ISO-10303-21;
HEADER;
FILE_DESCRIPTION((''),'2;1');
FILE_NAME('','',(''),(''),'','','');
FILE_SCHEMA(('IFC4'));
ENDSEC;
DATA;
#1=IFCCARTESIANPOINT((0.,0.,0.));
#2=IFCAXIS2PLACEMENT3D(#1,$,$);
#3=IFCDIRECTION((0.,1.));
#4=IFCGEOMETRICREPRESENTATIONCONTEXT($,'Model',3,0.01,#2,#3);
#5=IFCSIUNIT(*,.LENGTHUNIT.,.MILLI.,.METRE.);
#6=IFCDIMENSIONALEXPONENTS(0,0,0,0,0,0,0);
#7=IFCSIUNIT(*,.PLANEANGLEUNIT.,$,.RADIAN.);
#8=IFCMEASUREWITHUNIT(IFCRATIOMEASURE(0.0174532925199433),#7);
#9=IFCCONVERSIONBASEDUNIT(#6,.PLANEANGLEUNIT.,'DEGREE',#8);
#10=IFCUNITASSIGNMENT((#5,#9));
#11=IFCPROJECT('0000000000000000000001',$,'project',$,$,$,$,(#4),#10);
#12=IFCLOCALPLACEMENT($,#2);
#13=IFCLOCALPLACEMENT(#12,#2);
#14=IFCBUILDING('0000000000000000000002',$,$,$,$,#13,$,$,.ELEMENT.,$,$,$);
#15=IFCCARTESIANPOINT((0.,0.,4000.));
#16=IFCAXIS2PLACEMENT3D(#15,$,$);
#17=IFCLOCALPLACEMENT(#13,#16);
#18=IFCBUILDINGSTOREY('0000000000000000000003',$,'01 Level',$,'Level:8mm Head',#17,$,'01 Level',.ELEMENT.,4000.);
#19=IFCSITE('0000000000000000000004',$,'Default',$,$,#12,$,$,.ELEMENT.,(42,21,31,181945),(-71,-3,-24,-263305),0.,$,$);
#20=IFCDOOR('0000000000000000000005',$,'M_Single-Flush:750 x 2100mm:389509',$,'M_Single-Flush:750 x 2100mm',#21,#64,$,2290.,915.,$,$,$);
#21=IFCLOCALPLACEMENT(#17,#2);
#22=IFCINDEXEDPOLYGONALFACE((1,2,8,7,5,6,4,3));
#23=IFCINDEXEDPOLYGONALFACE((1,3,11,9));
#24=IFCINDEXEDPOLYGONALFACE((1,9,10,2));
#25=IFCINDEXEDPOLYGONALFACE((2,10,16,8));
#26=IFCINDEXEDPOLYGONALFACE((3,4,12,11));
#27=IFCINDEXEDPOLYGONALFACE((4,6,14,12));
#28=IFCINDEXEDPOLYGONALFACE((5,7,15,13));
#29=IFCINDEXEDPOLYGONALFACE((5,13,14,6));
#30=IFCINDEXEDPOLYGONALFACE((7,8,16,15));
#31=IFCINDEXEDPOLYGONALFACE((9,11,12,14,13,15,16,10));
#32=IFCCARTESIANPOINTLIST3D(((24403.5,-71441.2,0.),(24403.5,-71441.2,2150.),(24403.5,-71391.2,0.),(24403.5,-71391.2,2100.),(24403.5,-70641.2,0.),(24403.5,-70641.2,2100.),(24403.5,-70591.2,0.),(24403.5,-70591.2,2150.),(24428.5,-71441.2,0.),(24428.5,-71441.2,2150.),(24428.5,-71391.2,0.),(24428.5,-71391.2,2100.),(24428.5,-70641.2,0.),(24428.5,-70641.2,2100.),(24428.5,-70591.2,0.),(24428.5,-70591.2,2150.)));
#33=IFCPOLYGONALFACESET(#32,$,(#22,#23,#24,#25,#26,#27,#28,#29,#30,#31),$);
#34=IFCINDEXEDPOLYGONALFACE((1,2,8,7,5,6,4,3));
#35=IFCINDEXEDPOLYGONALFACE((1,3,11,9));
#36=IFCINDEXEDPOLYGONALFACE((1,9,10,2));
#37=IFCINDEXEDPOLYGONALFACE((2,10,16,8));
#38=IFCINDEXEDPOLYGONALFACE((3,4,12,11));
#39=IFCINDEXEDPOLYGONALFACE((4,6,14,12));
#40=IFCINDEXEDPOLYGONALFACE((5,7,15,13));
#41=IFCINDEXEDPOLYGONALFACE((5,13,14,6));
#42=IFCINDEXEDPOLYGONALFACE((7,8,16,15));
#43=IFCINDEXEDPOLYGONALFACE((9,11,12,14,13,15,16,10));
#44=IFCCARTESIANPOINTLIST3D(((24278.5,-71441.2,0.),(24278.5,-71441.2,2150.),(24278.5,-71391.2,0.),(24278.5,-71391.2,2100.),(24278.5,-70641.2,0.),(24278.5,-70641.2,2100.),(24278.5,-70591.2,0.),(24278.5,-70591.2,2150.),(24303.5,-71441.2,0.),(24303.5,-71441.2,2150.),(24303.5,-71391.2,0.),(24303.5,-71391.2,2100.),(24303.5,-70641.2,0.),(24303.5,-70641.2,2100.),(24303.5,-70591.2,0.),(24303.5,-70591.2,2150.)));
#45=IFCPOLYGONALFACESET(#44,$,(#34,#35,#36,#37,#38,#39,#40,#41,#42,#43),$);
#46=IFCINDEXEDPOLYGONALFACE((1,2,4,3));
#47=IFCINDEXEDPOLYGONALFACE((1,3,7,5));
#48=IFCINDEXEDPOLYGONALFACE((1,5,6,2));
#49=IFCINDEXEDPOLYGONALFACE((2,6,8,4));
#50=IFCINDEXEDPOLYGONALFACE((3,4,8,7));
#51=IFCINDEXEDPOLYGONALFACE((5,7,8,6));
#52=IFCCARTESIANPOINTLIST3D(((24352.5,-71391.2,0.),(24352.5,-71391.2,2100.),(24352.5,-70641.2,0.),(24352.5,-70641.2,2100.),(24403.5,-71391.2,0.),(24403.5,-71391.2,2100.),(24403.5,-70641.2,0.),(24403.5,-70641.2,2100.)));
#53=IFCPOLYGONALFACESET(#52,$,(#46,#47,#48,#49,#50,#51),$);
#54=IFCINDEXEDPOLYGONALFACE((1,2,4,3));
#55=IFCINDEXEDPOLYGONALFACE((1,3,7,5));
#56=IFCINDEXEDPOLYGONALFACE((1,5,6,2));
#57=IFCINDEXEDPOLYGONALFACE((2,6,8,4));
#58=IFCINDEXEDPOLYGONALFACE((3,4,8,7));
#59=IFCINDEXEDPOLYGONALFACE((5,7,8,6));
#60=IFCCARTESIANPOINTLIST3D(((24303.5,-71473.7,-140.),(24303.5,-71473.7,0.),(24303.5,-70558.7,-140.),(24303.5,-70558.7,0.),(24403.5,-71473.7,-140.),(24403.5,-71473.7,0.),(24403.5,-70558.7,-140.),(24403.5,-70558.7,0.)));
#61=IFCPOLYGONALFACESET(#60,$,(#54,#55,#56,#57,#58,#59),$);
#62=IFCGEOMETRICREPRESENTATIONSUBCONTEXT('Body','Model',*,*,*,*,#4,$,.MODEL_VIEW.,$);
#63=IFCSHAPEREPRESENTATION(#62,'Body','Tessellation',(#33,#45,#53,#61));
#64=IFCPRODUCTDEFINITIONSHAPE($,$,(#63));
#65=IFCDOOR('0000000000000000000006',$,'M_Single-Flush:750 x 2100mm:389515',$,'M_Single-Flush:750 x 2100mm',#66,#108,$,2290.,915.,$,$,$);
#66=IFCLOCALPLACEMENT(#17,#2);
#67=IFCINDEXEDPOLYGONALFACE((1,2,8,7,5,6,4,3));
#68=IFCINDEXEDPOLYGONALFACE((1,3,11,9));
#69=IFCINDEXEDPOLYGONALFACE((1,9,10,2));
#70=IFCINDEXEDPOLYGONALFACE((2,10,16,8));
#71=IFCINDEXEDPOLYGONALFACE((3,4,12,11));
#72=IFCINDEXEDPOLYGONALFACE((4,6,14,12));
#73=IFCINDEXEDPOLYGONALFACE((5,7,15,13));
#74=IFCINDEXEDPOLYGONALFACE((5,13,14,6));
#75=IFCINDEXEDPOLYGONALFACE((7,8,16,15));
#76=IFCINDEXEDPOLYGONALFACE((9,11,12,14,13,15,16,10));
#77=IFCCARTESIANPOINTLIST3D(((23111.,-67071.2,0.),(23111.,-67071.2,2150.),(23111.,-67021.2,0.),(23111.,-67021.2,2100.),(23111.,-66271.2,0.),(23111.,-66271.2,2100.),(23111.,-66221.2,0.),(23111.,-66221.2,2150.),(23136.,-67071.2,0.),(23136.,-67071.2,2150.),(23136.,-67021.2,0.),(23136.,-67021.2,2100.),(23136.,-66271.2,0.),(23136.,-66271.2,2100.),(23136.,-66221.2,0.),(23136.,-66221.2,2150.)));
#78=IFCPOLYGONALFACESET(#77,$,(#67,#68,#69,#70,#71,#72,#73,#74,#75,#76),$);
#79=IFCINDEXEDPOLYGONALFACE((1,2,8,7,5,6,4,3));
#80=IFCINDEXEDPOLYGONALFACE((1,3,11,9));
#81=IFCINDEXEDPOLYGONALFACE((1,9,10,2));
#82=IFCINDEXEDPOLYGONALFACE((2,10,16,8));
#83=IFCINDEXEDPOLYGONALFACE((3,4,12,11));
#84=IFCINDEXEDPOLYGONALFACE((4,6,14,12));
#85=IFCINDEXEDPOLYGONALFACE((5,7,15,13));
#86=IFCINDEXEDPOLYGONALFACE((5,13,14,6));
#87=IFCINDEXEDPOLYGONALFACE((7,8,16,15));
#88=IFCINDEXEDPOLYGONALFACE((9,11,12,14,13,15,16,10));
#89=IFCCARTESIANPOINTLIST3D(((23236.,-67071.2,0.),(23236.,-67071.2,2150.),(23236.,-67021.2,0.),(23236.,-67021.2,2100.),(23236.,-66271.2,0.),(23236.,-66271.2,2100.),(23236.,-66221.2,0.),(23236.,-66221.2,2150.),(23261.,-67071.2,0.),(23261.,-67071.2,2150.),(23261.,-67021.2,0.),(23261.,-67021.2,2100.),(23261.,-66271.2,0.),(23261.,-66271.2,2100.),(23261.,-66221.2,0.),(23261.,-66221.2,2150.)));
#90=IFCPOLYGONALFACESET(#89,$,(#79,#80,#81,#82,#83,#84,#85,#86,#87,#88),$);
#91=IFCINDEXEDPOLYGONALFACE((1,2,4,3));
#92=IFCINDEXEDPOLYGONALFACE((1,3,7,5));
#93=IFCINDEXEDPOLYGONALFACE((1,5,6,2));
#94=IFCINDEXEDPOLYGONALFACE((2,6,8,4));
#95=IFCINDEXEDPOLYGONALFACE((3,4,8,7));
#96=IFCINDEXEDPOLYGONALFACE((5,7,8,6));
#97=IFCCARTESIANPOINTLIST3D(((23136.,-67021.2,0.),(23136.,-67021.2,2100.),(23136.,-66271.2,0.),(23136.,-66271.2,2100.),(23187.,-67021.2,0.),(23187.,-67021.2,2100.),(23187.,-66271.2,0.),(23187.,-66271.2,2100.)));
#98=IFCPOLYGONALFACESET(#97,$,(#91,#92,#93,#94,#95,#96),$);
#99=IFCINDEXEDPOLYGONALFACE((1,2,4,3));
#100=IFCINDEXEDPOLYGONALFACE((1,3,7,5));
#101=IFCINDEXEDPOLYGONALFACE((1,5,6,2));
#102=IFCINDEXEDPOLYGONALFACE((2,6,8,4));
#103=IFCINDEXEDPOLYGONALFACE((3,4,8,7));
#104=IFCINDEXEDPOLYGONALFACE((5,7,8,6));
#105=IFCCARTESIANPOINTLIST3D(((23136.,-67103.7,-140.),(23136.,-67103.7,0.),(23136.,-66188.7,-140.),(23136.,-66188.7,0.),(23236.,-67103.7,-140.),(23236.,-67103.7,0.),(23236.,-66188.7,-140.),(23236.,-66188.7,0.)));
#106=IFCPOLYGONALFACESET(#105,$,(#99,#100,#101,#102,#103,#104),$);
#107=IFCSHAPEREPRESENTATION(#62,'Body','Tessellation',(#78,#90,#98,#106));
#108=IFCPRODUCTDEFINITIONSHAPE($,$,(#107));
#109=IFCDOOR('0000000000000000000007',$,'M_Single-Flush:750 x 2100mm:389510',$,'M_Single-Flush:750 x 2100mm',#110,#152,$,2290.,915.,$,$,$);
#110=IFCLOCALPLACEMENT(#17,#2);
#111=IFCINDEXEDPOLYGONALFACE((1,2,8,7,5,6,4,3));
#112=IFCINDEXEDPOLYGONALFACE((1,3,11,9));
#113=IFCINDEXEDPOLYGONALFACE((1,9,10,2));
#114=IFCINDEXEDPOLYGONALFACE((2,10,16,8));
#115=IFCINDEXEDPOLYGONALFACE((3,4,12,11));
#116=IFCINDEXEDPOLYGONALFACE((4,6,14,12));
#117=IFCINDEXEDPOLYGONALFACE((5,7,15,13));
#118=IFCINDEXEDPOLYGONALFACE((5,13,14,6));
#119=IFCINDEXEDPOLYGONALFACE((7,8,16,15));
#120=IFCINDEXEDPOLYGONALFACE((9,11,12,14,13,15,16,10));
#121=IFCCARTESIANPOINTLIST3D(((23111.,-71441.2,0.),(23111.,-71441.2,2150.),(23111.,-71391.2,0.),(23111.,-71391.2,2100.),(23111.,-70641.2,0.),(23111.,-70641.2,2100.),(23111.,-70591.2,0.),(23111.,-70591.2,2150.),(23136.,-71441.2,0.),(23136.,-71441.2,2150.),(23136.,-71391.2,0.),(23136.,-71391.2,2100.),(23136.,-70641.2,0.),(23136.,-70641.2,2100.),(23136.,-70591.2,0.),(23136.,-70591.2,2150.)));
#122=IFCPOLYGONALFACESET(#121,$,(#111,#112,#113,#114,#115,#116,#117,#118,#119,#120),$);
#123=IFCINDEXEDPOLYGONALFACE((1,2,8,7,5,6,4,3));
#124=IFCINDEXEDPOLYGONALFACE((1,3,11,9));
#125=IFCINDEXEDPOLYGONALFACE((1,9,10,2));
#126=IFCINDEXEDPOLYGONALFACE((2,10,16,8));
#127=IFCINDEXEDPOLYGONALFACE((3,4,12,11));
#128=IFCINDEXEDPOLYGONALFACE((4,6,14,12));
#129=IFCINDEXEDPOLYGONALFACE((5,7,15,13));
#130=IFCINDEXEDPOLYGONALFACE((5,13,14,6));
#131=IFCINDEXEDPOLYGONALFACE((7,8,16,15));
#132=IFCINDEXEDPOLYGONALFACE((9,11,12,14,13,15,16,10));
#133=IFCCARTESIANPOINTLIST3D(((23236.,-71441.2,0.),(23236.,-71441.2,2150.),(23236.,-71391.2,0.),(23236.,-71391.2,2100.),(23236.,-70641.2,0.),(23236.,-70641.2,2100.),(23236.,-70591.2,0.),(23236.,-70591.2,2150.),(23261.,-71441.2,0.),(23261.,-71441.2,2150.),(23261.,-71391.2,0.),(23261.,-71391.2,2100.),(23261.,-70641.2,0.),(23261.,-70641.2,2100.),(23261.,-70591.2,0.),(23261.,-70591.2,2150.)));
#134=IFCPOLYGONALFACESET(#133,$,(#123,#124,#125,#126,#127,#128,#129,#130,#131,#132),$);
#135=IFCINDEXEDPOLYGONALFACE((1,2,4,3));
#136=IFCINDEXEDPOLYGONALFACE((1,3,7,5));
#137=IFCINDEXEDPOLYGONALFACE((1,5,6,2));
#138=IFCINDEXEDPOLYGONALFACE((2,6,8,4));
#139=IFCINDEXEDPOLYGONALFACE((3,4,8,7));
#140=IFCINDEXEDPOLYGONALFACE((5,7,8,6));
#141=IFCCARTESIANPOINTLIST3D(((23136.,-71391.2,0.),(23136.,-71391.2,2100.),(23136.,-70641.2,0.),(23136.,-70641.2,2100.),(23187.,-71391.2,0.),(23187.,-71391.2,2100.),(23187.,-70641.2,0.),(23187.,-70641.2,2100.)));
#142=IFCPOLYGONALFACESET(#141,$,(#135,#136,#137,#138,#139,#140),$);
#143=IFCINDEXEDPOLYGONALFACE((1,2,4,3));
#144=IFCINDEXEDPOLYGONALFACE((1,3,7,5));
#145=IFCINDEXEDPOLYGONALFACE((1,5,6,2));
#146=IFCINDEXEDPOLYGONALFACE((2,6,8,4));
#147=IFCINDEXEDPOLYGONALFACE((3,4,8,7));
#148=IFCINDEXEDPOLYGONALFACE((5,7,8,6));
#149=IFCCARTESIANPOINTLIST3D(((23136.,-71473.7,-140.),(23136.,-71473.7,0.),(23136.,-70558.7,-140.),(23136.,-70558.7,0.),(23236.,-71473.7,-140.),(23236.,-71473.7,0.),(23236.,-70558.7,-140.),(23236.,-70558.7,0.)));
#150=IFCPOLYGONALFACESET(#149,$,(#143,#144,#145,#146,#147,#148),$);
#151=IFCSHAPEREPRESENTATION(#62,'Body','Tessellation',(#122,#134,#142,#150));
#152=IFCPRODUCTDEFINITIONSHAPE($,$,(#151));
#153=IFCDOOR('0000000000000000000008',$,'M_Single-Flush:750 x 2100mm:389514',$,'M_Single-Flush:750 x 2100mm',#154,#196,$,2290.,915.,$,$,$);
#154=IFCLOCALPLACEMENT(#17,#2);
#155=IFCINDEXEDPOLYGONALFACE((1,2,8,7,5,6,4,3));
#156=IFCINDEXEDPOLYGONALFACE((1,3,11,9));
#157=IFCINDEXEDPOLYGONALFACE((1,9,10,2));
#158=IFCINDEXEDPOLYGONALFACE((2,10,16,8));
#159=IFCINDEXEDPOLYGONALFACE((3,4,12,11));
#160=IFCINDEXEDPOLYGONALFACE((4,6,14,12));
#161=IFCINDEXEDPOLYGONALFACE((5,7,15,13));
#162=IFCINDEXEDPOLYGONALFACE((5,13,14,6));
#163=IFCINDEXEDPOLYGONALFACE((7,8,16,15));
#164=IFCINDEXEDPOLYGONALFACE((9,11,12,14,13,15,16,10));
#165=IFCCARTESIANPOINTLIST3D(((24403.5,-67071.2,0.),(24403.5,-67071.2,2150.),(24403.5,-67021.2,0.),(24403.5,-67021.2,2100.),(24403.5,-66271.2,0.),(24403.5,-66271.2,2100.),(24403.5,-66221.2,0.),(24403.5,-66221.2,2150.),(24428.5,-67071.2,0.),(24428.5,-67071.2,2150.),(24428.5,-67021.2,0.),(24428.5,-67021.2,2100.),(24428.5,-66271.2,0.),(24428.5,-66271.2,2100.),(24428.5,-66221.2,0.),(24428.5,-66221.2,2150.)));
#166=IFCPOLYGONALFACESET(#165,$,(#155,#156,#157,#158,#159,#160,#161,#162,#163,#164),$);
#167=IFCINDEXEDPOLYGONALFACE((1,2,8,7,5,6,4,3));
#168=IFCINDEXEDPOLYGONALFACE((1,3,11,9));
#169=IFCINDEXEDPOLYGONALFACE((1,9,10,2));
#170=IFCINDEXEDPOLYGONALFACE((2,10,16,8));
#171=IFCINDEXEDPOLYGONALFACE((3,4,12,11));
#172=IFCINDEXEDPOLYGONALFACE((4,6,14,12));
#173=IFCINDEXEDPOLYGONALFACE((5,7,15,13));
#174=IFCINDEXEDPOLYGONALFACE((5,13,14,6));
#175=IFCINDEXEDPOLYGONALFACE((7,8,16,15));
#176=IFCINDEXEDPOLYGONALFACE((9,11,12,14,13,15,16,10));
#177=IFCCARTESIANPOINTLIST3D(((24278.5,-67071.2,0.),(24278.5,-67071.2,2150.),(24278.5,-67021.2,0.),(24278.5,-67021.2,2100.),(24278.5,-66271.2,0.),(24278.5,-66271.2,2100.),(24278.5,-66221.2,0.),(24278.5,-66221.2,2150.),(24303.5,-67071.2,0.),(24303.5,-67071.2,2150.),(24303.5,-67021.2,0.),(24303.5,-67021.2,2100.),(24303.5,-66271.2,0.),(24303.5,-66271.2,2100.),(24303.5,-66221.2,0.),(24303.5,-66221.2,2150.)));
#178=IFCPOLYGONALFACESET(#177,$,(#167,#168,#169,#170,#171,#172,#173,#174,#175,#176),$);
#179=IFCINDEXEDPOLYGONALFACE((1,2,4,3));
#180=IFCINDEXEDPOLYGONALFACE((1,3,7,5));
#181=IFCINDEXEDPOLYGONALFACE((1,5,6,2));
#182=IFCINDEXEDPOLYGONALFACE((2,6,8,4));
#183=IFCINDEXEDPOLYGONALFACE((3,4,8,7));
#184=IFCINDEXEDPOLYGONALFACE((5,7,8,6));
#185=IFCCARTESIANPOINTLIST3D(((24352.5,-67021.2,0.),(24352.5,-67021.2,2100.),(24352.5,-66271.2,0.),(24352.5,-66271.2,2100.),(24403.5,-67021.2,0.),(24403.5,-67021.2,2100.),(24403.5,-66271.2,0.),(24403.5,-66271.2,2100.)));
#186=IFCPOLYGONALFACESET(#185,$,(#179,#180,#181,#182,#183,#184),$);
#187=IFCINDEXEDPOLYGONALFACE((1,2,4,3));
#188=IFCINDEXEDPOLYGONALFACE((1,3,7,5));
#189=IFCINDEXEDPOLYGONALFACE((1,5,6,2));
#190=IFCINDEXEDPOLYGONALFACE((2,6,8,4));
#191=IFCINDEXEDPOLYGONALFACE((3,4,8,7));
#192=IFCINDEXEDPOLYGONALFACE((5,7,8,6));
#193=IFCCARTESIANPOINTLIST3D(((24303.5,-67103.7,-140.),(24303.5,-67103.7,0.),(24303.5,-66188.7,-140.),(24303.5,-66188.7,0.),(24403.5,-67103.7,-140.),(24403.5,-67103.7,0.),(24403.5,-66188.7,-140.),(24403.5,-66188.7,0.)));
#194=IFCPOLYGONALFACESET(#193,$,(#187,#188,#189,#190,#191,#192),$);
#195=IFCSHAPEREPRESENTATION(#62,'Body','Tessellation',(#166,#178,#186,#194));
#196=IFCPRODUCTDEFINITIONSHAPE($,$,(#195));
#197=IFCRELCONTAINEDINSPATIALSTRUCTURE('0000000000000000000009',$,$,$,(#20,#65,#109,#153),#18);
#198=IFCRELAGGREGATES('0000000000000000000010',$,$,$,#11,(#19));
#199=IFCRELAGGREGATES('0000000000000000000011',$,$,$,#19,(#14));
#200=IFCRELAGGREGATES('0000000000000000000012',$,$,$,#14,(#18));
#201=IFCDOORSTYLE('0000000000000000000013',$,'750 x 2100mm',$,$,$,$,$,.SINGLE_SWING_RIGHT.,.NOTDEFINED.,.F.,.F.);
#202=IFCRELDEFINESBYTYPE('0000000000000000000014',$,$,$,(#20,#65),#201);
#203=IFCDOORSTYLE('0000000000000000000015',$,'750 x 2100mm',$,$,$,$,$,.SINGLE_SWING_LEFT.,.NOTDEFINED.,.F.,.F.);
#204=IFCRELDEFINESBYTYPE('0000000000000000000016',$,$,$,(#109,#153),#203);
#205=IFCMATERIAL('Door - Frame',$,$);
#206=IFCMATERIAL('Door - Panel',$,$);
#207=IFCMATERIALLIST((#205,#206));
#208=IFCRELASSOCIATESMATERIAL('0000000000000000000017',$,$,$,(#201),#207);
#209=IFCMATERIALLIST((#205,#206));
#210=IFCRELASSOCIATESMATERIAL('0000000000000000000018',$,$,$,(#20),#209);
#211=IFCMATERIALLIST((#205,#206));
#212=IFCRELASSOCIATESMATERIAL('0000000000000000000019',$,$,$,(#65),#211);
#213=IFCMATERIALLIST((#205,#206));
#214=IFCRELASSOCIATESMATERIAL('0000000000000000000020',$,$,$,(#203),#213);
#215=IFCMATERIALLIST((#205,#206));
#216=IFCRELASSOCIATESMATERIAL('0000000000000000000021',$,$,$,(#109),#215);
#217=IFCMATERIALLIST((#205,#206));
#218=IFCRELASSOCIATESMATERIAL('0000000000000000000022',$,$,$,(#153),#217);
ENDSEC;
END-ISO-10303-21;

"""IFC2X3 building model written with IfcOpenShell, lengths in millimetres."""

from ifc_helpers import new_model, entity, si_unit, converted_unit, direction, frame, frame_2d, origin, origin_2d_with_axis, place, context, subcontext, project, spatial, polyline, rectangle, outline, extrude, source, transform, mapped, material, material_list, type_object, type_shapes, element, save


model = new_model("IFC2X3")

# Units and contexts
model_context = context("Model", 3, precision=0.01, world=origin(), true_north=direction((0.0, 1.0)))
body_context = subcontext(model_context, "Body", "Model", "MODEL_VIEW")
ifc_project = project(units=[si_unit("LENGTHUNIT", "METRE", prefix="MILLI"), converted_unit("PLANEANGLEUNIT", "DEGREE", entity("IfcRatioMeasure", 0.0174532925199433), si_unit("PLANEANGLEUNIT", "RADIAN"), dimensions=[0, 0, 0, 0, 0, 0, 0])], contexts=[model_context])

# Site, building, storey
site_placement = place(None, origin())
site = spatial("IfcSite", under=ifc_project, at=site_placement, Name="Default", CompositionType="ELEMENT", RefLatitude=(42, 21, 31, 181945), RefLongitude=(-71, -3, -24, -263305), RefElevation=0.0)
building_placement = place(site_placement, origin())
building = spatial("IfcBuilding", under=site, at=building_placement, CompositionType="ELEMENT")
storey_placement = place(building_placement, frame((0.0, 0.0, 4000.0)))
storey = spatial("IfcBuildingStorey", under=building, at=storey_placement, Name="01 Level", ObjectType="Level:8mm Head", LongName="01 Level", CompositionType="ELEMENT", Elevation=4000.0)

# Shared definitions
ifc_material_1 = material(Name="Door - Frame")
ifc_material_2 = material(Name="Door - Panel")

# Doors
ifc_material_list_1 = material_list([ifc_material_1, ifc_material_2])
ifc_material_list_2 = material_list([ifc_material_1, ifc_material_2])
door_style_1 = type_object("IfcDoorStyle", Name="750 x 2100mm", ConstructionType="NOTDEFINED", OperationType="SINGLE_SWING_RIGHT", ParameterTakesPrecedence=False, Sizeable=False, material=ifc_material_list_2)
shared_shape_1 = source(origin(), body_context, "Body", "SweptSolid", [
    extrude(outline(polyline([(-425.0, -1087.5), (425.0, -1087.5), (425.0, 1062.5), (375.0, 1062.5), (375.0, -1037.5), (-375.0, -1037.5), (-375.0, 1062.5), (-425.0, 1062.5), (-425.0, -1087.5)])), frame((375.0, 100.0, 1202.5), z_axis=(0.0, 1.0, 0.0), x_axis=(1.0, 0.0, 0.0)), (0.0, 0.0, 1.0), 25.0),
    extrude(outline(polyline([(-1087.5, -425.0), (1062.5, -425.0), (1062.5, -375.0), (-1037.5, -375.0), (-1037.5, 375.0), (1062.5, 375.0), (1062.5, 425.0), (-1087.5, 425.0), (-1087.5, -425.0)])), frame((375.0, -25.0, 1202.5), z_axis=(0.0, 1.0, 0.0), x_axis=(0.0, 0.0, -1.0)), (0.0, 0.0, 1.0), 25.0),
    extrude(rectangle(XDim=51.0, YDim=750.0, at=origin_2d_with_axis()), frame((375.0, 74.5, 140.0), z_axis=(0.0, 0.0, 1.0), x_axis=(0.0, 1.0, 0.0)), (0.0, 0.0, 1.0), 2100.0),
    extrude(rectangle(XDim=915.0, YDim=100.0, at=frame_2d((0.0, 0.0), x_axis=(1.0, 0.0))), frame((375.0, 50.0, 0.0), z_axis=(0.0, 0.0, 1.0), x_axis=(-1.0, 0.0, 0.0)), (0.0, 0.0, 1.0), 140.0),
])
type_shapes(door_style_1, [shared_shape_1])
door_1_placement = place(storey_placement, frame((24303.5, -70641.2, -140.0), z_axis=(0.0, 0.0, 1.0), x_axis=(0.0, -1.0, 0.0)))
element("IfcDoor", 1, at=door_1_placement, inside=storey, type_object=door_style_1, material=ifc_material_list_1, Name="M_Single-Flush:750 x 2100mm:389509", ObjectType="M_Single-Flush:750 x 2100mm", OverallHeight=2290.0, OverallWidth=915.0, context=body_context, shape_type="MappedRepresentation", body=[
    mapped(shared_shape_1, transform((0.0, 0.0, 0.0), scale=1.0)),
])
ifc_material_list_3 = material_list([ifc_material_1, ifc_material_2])
door_2_placement = place(storey_placement, frame((23236.0, -67021.2, -140.0), z_axis=(0.0, 0.0, 1.0), x_axis=(0.0, 1.0, 0.0)))
element("IfcDoor", 2, at=door_2_placement, inside=storey, type_object=door_style_1, material=ifc_material_list_3, Name="M_Single-Flush:750 x 2100mm:389515", ObjectType="M_Single-Flush:750 x 2100mm", OverallHeight=2290.0, OverallWidth=915.0, context=body_context, shape_type="MappedRepresentation", body=[
    mapped(shared_shape_1, transform((0.0, 0.0, 0.0), scale=1.0)),
])
ifc_material_list_4 = material_list([ifc_material_1, ifc_material_2])
ifc_material_list_5 = material_list([ifc_material_1, ifc_material_2])
door_style_2 = type_object("IfcDoorStyle", Name="750 x 2100mm", ConstructionType="NOTDEFINED", OperationType="SINGLE_SWING_LEFT", ParameterTakesPrecedence=False, Sizeable=False, material=ifc_material_list_5)
shared_shape_2 = source(origin(), body_context, "Body", "SweptSolid", [
    extrude(outline(polyline([(-425.0, -1087.5), (425.0, -1087.5), (425.0, 1062.5), (375.0, 1062.5), (375.0, -1037.5), (-375.0, -1037.5), (-375.0, 1062.5), (-425.0, 1062.5), (-425.0, -1087.5)])), frame((375.0, 125.0, 1202.5), z_axis=(0.0, -1.0, 0.0), x_axis=(-1.0, 0.0, 0.0)), (0.0, 0.0, 1.0), 25.0),
    extrude(outline(polyline([(-1087.5, -425.0), (1062.5, -425.0), (1062.5, -375.0), (-1037.5, -375.0), (-1037.5, 375.0), (1062.5, 375.0), (1062.5, 425.0), (-1087.5, 425.0), (-1087.5, -425.0)])), frame((375.0, 0.0, 1202.5), z_axis=(0.0, -1.0, 0.0), x_axis=(0.0, 0.0, -1.0)), (0.0, 0.0, 1.0), 25.0),
    extrude(rectangle(XDim=750.0, YDim=51.0, at=origin_2d_with_axis()), frame((375.0, 74.5, 140.0)), (0.0, 0.0, 1.0), 2100.0),
    extrude(rectangle(XDim=100.0, YDim=915.0, at=origin_2d_with_axis()), frame((375.0, 50.0, 0.0), z_axis=(0.0, 0.0, 1.0), x_axis=(0.0, -1.0, 0.0)), (0.0, 0.0, 1.0), 140.0),
])
type_shapes(door_style_2, [shared_shape_2])
door_3_placement = place(storey_placement, frame((23236.0, -71391.2, -140.0), z_axis=(0.0, 0.0, 1.0), x_axis=(0.0, 1.0, 0.0)))
element("IfcDoor", 3, at=door_3_placement, inside=storey, type_object=door_style_2, material=ifc_material_list_4, Name="M_Single-Flush:750 x 2100mm:389510", ObjectType="M_Single-Flush:750 x 2100mm", OverallHeight=2290.0, OverallWidth=915.0, context=body_context, shape_type="MappedRepresentation", body=[
    mapped(shared_shape_2, transform((0.0, 0.0, 0.0), scale=1.0)),
])
ifc_material_list_6 = material_list([ifc_material_1, ifc_material_2])
door_4_placement = place(storey_placement, frame((24303.5, -66271.2, -140.0), z_axis=(0.0, 0.0, 1.0), x_axis=(0.0, -1.0, 0.0)))
element("IfcDoor", 4, at=door_4_placement, inside=storey, type_object=door_style_2, material=ifc_material_list_6, Name="M_Single-Flush:750 x 2100mm:389514", ObjectType="M_Single-Flush:750 x 2100mm", OverallHeight=2290.0, OverallWidth=915.0, context=body_context, shape_type="MappedRepresentation", body=[
    mapped(shared_shape_2, transform((0.0, 0.0, 0.0), scale=1.0)),
])

save(model, "model.ifc")
